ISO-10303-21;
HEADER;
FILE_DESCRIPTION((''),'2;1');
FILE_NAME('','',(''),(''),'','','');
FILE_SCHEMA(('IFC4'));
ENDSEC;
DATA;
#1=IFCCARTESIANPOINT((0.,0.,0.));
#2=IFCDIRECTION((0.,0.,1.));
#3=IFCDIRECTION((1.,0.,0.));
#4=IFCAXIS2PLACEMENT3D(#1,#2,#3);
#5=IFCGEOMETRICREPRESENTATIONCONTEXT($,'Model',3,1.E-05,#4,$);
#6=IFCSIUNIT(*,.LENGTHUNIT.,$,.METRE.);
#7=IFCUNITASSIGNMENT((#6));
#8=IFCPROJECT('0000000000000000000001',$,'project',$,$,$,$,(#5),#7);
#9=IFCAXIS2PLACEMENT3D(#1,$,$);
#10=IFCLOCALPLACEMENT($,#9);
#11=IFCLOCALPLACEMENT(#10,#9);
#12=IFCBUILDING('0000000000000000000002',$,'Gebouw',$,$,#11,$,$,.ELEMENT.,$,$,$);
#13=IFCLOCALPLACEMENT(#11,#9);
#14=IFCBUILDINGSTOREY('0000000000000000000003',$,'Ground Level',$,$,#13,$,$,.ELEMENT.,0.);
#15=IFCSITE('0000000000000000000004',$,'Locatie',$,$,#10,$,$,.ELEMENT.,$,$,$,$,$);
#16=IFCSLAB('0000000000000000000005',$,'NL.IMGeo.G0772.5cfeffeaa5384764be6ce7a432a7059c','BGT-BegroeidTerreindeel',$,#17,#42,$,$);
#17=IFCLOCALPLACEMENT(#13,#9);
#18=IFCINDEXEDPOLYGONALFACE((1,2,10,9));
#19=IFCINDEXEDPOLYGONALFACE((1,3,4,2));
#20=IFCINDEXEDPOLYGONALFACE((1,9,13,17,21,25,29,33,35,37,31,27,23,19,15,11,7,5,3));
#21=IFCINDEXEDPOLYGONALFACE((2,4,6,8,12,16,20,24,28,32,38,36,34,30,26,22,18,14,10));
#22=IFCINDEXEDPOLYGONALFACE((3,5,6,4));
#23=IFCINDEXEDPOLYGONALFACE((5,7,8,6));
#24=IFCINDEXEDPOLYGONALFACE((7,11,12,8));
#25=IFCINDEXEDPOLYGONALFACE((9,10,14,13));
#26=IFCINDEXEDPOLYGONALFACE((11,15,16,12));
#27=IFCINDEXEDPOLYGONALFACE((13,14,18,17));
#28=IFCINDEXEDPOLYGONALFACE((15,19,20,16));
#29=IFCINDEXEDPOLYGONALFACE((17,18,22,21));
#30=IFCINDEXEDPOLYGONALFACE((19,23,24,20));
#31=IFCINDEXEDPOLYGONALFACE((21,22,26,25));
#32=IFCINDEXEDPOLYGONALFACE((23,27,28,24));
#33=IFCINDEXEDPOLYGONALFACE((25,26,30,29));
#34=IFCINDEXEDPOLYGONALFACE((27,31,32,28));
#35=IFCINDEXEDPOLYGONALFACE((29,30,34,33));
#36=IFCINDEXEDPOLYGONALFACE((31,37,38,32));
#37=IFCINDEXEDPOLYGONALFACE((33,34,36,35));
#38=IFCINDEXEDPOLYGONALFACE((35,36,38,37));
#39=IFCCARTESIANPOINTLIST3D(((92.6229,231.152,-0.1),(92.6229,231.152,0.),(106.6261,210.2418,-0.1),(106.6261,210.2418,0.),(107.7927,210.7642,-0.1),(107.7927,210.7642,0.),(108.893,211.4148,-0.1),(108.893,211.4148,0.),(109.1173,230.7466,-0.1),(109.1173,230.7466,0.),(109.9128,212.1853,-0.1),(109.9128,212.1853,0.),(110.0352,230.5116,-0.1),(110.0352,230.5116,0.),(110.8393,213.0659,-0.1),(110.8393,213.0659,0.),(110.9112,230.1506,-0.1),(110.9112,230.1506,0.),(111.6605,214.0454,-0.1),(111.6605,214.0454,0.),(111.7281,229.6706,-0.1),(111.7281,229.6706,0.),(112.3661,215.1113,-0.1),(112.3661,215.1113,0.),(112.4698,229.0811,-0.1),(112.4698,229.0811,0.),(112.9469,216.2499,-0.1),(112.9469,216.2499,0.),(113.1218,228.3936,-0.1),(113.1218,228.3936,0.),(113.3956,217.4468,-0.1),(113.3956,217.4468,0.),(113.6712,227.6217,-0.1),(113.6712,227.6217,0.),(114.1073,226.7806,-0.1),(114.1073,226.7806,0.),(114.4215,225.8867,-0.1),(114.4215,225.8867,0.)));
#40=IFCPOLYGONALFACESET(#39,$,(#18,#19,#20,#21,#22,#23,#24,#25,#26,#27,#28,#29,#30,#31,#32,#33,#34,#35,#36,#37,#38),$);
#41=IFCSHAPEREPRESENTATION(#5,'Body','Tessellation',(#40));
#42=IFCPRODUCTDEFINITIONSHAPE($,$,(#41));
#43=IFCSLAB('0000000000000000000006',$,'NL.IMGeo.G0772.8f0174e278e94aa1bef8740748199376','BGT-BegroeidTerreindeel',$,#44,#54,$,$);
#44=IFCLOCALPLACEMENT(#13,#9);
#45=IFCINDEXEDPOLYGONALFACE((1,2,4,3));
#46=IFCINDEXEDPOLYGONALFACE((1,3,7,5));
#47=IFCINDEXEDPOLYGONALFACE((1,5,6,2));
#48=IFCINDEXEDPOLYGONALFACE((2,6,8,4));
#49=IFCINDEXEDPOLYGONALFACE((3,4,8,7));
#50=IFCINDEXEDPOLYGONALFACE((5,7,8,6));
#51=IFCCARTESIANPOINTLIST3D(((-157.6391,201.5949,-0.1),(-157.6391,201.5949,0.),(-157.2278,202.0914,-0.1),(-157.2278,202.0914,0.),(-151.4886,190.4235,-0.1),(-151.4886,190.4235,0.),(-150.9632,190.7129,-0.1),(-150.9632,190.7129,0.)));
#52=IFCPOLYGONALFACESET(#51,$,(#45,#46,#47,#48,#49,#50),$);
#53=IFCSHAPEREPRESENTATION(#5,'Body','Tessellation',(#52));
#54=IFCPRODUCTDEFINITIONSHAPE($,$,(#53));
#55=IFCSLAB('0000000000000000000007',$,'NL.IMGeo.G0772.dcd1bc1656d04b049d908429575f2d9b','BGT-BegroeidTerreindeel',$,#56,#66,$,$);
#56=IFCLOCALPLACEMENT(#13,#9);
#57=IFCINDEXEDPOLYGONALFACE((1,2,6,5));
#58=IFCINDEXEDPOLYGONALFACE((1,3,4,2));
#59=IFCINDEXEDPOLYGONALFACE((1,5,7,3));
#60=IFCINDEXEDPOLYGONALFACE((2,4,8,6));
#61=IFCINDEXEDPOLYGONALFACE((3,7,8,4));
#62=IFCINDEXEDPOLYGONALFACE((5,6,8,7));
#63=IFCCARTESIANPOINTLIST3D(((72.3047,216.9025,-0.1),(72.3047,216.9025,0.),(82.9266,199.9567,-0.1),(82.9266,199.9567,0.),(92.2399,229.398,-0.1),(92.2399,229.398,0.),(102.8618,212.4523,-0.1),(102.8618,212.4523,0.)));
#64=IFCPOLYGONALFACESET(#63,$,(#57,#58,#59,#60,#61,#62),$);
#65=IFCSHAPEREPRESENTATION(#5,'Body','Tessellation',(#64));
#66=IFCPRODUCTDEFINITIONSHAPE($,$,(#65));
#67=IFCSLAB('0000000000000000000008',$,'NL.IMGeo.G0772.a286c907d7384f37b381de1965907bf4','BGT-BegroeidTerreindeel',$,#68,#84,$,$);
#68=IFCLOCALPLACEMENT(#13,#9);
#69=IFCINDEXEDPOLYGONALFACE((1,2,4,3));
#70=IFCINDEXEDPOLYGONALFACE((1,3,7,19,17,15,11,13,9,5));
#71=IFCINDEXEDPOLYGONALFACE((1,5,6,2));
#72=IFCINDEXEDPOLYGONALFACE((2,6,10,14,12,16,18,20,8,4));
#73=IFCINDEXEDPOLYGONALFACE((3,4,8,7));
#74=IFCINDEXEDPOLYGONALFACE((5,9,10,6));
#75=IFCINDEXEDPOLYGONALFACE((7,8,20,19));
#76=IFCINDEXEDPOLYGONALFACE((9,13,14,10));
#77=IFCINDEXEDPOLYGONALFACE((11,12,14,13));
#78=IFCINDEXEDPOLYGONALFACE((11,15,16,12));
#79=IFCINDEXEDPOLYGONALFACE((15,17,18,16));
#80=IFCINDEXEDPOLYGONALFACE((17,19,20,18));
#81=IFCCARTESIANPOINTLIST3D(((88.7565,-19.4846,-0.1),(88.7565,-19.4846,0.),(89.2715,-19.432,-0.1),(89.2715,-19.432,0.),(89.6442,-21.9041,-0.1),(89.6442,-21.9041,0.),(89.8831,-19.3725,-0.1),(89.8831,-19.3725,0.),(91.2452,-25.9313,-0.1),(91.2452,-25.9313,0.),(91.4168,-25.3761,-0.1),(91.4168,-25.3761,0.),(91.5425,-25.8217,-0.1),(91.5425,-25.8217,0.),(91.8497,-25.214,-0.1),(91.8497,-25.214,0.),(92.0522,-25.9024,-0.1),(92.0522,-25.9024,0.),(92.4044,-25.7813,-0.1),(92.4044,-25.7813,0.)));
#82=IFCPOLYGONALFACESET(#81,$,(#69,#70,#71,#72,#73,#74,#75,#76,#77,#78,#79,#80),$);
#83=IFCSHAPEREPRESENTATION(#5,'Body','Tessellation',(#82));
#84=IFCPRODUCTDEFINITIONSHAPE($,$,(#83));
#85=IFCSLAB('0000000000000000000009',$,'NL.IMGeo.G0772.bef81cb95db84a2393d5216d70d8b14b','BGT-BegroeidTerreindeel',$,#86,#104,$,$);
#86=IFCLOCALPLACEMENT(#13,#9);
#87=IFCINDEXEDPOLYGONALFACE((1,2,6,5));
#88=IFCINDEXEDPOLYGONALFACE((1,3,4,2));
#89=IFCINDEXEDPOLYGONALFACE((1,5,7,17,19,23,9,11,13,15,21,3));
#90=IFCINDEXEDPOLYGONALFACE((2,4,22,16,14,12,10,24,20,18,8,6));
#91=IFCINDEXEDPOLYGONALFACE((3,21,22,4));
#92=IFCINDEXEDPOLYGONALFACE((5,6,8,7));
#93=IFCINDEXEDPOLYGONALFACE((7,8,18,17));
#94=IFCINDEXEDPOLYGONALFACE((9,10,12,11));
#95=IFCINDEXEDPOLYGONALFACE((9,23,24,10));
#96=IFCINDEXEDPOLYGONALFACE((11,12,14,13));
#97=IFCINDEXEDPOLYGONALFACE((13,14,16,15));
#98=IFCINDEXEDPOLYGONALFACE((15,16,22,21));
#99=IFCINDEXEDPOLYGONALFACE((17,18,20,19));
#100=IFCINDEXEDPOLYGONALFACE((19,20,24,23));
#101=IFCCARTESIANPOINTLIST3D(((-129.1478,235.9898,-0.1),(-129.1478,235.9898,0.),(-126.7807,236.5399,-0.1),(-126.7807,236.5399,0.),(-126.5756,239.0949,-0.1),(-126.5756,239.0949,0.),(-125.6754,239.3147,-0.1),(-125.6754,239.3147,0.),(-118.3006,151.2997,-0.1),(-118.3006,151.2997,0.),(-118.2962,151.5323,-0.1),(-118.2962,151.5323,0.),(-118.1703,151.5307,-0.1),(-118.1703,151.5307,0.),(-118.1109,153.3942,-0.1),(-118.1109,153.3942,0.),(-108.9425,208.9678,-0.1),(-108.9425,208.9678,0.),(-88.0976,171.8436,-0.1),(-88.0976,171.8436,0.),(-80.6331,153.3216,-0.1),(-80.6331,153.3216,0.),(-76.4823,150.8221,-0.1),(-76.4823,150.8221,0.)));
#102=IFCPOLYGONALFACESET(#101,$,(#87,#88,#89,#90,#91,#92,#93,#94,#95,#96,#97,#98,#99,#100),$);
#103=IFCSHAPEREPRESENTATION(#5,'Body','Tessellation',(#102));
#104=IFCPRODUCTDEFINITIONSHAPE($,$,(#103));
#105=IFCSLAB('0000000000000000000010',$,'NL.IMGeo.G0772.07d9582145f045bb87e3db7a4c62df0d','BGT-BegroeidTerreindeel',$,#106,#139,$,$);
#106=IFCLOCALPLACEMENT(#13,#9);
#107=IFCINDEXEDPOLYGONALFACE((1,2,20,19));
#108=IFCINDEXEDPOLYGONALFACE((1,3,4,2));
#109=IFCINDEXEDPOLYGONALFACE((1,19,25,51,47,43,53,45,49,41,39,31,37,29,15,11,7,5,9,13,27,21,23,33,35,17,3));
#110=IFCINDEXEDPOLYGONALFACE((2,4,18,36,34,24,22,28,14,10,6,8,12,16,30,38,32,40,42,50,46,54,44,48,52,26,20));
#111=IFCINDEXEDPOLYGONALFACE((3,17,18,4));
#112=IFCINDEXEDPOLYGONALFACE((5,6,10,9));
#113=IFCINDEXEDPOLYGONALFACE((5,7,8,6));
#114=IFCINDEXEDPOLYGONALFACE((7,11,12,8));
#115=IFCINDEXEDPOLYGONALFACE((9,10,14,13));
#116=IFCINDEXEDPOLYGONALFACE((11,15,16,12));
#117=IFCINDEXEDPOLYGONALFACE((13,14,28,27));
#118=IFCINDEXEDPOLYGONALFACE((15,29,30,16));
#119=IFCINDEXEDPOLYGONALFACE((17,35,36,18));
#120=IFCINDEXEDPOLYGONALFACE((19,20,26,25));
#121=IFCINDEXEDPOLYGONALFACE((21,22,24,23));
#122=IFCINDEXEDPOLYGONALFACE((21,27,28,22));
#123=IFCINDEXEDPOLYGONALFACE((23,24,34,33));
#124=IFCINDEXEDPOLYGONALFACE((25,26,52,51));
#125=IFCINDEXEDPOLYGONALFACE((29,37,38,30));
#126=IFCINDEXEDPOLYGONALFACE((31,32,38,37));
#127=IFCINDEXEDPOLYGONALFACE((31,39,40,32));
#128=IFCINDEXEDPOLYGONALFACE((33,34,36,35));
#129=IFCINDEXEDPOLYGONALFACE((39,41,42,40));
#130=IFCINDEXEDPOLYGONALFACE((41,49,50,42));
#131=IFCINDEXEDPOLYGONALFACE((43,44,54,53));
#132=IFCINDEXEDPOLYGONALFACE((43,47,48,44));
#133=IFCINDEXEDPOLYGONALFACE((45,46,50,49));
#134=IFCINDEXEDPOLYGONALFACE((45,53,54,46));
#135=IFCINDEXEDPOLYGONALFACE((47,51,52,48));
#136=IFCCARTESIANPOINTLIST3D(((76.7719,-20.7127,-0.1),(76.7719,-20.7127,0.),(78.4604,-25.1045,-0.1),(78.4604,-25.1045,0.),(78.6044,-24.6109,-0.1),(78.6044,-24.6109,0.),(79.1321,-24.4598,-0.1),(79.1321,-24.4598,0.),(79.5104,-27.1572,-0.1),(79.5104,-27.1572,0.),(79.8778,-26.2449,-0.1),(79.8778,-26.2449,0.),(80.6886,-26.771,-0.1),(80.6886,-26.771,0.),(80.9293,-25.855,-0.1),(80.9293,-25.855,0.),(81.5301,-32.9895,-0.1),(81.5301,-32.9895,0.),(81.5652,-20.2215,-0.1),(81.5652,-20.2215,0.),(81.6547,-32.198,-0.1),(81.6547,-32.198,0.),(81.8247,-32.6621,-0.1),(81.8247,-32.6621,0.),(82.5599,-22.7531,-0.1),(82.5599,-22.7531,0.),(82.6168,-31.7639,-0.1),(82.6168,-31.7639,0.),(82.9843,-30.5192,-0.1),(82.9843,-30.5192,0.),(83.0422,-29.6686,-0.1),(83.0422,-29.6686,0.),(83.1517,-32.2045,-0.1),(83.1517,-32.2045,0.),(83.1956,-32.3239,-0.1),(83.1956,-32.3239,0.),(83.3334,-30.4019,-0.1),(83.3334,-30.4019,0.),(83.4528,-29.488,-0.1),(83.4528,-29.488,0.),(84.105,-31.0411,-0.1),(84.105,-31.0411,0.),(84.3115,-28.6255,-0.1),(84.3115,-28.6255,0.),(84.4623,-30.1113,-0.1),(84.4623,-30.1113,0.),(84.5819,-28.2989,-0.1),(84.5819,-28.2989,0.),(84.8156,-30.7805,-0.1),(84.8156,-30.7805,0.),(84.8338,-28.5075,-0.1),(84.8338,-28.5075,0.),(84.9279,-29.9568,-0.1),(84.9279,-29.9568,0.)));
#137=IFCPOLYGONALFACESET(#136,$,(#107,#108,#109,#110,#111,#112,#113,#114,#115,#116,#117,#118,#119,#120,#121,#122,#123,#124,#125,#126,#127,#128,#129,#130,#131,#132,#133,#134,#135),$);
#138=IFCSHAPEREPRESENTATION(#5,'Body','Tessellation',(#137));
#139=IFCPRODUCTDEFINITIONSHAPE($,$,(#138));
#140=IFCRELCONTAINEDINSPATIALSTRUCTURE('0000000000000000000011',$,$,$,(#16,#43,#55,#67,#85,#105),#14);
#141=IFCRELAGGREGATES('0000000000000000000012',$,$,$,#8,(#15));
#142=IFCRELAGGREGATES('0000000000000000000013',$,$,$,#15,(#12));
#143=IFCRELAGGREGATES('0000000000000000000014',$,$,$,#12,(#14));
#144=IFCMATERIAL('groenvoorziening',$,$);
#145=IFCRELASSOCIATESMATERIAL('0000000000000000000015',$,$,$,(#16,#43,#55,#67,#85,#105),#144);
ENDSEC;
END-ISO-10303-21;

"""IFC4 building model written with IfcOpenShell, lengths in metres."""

from ifc_helpers import new_model, si_unit, frame, origin, origin_with_axes, place, context, project, spatial, polyline, outline, extrude, material, element, save


model = new_model("IFC4")

# Units and contexts
model_context = context("Model", 3, precision=1e-05, world=origin_with_axes())
ifc_project = project(units=[si_unit("LENGTHUNIT", "METRE")], contexts=[model_context])

# Site, building, storey
site_placement = place(None, origin())
site = spatial("IfcSite", under=ifc_project, at=site_placement, Name="Locatie", CompositionType="ELEMENT")
building_placement = place(site_placement, origin())
building = spatial("IfcBuilding", under=site, at=building_placement, Name="Gebouw", CompositionType="ELEMENT")
storey_placement = place(building_placement, origin())
storey = spatial("IfcBuildingStorey", under=building, at=storey_placement, Name="Ground Level", CompositionType="ELEMENT", Elevation=0.0)

# Slabs
ifc_material = material(Name="groenvoorziening")
slab_1_placement = place(storey_placement, origin())
element("IfcSlab", 1, at=slab_1_placement, inside=storey, material=ifc_material, Name="NL.IMGeo.G0772.5cfeffeaa5384764be6ce7a432a7059c", Description="BGT-BegroeidTerreindeel", context=model_context, shape_type="SweptSolid", body=[
    extrude(outline(polyline([(110.0352, 230.5116), (110.9112, 230.1506), (111.7281, 229.6706), (112.4698, 229.0811), (113.1218, 228.3936), (113.6712, 227.6217), (114.1073, 226.7806), (114.4215, 225.8867), (113.3956, 217.4468), (112.9469, 216.2499), (112.3661, 215.1113), (111.6605, 214.0454), (110.8393, 213.0659), (109.9128, 212.1853), (108.893, 211.4148), (107.7927, 210.7642), (106.6261, 210.2418), (92.6229, 231.152), (109.1173, 230.7466), (110.0352, 230.5116)])), frame((0.0, 0.0, -0.1), z_axis=(0.0, 0.0, 1.0), x_axis=(1.0, 0.0, 0.0)), (0.0, 0.0, 1.0), 0.1),
])
slab_2_placement = place(storey_placement, origin())
element("IfcSlab", 2, at=slab_2_placement, inside=storey, material=ifc_material, Name="NL.IMGeo.G0772.8f0174e278e94aa1bef8740748199376", Description="BGT-BegroeidTerreindeel", context=model_context, shape_type="SweptSolid", body=[
    extrude(outline(polyline([(-150.9632, 190.7129), (-151.4886, 190.4235), (-157.6391, 201.5949), (-157.2278, 202.0914), (-150.9632, 190.7129)])), frame((0.0, 0.0, -0.1), z_axis=(0.0, 0.0, 1.0), x_axis=(1.0, 0.0, 0.0)), (0.0, 0.0, 1.0), 0.1),
])
slab_3_placement = place(storey_placement, origin())
element("IfcSlab", 3, at=slab_3_placement, inside=storey, material=ifc_material, Name="NL.IMGeo.G0772.dcd1bc1656d04b049d908429575f2d9b", Description="BGT-BegroeidTerreindeel", context=model_context, shape_type="SweptSolid", body=[
    extrude(outline(polyline([(102.8618, 212.4523), (82.9266, 199.9567), (72.3047, 216.9025), (92.2399, 229.398), (102.8618, 212.4523)])), frame((0.0, 0.0, -0.1), z_axis=(0.0, 0.0, 1.0), x_axis=(1.0, 0.0, 0.0)), (0.0, 0.0, 1.0), 0.1),
])
slab_4_placement = place(storey_placement, origin())
element("IfcSlab", 4, at=slab_4_placement, inside=storey, material=ifc_material, Name="NL.IMGeo.G0772.a286c907d7384f37b381de1965907bf4", Description="BGT-BegroeidTerreindeel", context=model_context, shape_type="SweptSolid", body=[
    extrude(outline(polyline([(92.4044, -25.7813), (92.0522, -25.9024), (91.8497, -25.214), (91.4168, -25.3761), (91.5425, -25.8217), (91.2452, -25.9313), (89.6442, -21.9041), (88.7565, -19.4846), (89.2715, -19.432), (89.8831, -19.3725), (92.4044, -25.7813)])), frame((0.0, 0.0, -0.1), z_axis=(0.0, 0.0, 1.0), x_axis=(1.0, 0.0, 0.0)), (0.0, 0.0, 1.0), 0.1),
])
slab_5_placement = place(storey_placement, origin())
element("IfcSlab", 5, at=slab_5_placement, inside=storey, material=ifc_material, Name="NL.IMGeo.G0772.bef81cb95db84a2393d5216d70d8b14b", Description="BGT-BegroeidTerreindeel", context=model_context, shape_type="SweptSolid", body=[
    extrude(outline(polyline([(-125.6754, 239.3147), (-108.9425, 208.9678), (-88.0976, 171.8436), (-76.4823, 150.8221), (-118.3006, 151.2997), (-118.2962, 151.5323), (-118.1703, 151.5307), (-118.1109, 153.3942), (-80.6331, 153.3216), (-126.7807, 236.5399), (-129.1478, 235.9898), (-126.5756, 239.0949), (-125.6754, 239.3147)])), frame((0.0, 0.0, -0.1), z_axis=(0.0, 0.0, 1.0), x_axis=(1.0, 0.0, 0.0)), (0.0, 0.0, 1.0), 0.1),
])
slab_6_placement = place(storey_placement, origin())
element("IfcSlab", 6, at=slab_6_placement, inside=storey, material=ifc_material, Name="NL.IMGeo.G0772.07d9582145f045bb87e3db7a4c62df0d", Description="BGT-BegroeidTerreindeel", context=model_context, shape_type="SweptSolid", body=[
    extrude(outline(polyline([(82.5599, -22.7531), (84.8338, -28.5075), (84.5819, -28.2989), (84.3115, -28.6255), (84.9279, -29.9568), (84.4623, -30.1113), (84.8156, -30.7805), (84.105, -31.0411), (83.4528, -29.488), (83.0422, -29.6686), (83.3334, -30.4019), (82.9843, -30.5192), (80.9293, -25.855), (79.8778, -26.2449), (79.1321, -24.4598), (78.6044, -24.6109), (79.5104, -27.1572), (80.6886, -26.771), (82.6168, -31.7639), (81.6547, -32.198), (81.8247, -32.6621), (83.1517, -32.2045), (83.1956, -32.3239), (81.5301, -32.9895), (78.4604, -25.1045), (76.7719, -20.7127), (81.5652, -20.2215), (82.5599, -22.7531)])), frame((0.0, 0.0, -0.1), z_axis=(0.0, 0.0, 1.0), x_axis=(1.0, 0.0, 0.0)), (0.0, 0.0, 1.0), 0.1),
])

save(model, "model.ifc")
